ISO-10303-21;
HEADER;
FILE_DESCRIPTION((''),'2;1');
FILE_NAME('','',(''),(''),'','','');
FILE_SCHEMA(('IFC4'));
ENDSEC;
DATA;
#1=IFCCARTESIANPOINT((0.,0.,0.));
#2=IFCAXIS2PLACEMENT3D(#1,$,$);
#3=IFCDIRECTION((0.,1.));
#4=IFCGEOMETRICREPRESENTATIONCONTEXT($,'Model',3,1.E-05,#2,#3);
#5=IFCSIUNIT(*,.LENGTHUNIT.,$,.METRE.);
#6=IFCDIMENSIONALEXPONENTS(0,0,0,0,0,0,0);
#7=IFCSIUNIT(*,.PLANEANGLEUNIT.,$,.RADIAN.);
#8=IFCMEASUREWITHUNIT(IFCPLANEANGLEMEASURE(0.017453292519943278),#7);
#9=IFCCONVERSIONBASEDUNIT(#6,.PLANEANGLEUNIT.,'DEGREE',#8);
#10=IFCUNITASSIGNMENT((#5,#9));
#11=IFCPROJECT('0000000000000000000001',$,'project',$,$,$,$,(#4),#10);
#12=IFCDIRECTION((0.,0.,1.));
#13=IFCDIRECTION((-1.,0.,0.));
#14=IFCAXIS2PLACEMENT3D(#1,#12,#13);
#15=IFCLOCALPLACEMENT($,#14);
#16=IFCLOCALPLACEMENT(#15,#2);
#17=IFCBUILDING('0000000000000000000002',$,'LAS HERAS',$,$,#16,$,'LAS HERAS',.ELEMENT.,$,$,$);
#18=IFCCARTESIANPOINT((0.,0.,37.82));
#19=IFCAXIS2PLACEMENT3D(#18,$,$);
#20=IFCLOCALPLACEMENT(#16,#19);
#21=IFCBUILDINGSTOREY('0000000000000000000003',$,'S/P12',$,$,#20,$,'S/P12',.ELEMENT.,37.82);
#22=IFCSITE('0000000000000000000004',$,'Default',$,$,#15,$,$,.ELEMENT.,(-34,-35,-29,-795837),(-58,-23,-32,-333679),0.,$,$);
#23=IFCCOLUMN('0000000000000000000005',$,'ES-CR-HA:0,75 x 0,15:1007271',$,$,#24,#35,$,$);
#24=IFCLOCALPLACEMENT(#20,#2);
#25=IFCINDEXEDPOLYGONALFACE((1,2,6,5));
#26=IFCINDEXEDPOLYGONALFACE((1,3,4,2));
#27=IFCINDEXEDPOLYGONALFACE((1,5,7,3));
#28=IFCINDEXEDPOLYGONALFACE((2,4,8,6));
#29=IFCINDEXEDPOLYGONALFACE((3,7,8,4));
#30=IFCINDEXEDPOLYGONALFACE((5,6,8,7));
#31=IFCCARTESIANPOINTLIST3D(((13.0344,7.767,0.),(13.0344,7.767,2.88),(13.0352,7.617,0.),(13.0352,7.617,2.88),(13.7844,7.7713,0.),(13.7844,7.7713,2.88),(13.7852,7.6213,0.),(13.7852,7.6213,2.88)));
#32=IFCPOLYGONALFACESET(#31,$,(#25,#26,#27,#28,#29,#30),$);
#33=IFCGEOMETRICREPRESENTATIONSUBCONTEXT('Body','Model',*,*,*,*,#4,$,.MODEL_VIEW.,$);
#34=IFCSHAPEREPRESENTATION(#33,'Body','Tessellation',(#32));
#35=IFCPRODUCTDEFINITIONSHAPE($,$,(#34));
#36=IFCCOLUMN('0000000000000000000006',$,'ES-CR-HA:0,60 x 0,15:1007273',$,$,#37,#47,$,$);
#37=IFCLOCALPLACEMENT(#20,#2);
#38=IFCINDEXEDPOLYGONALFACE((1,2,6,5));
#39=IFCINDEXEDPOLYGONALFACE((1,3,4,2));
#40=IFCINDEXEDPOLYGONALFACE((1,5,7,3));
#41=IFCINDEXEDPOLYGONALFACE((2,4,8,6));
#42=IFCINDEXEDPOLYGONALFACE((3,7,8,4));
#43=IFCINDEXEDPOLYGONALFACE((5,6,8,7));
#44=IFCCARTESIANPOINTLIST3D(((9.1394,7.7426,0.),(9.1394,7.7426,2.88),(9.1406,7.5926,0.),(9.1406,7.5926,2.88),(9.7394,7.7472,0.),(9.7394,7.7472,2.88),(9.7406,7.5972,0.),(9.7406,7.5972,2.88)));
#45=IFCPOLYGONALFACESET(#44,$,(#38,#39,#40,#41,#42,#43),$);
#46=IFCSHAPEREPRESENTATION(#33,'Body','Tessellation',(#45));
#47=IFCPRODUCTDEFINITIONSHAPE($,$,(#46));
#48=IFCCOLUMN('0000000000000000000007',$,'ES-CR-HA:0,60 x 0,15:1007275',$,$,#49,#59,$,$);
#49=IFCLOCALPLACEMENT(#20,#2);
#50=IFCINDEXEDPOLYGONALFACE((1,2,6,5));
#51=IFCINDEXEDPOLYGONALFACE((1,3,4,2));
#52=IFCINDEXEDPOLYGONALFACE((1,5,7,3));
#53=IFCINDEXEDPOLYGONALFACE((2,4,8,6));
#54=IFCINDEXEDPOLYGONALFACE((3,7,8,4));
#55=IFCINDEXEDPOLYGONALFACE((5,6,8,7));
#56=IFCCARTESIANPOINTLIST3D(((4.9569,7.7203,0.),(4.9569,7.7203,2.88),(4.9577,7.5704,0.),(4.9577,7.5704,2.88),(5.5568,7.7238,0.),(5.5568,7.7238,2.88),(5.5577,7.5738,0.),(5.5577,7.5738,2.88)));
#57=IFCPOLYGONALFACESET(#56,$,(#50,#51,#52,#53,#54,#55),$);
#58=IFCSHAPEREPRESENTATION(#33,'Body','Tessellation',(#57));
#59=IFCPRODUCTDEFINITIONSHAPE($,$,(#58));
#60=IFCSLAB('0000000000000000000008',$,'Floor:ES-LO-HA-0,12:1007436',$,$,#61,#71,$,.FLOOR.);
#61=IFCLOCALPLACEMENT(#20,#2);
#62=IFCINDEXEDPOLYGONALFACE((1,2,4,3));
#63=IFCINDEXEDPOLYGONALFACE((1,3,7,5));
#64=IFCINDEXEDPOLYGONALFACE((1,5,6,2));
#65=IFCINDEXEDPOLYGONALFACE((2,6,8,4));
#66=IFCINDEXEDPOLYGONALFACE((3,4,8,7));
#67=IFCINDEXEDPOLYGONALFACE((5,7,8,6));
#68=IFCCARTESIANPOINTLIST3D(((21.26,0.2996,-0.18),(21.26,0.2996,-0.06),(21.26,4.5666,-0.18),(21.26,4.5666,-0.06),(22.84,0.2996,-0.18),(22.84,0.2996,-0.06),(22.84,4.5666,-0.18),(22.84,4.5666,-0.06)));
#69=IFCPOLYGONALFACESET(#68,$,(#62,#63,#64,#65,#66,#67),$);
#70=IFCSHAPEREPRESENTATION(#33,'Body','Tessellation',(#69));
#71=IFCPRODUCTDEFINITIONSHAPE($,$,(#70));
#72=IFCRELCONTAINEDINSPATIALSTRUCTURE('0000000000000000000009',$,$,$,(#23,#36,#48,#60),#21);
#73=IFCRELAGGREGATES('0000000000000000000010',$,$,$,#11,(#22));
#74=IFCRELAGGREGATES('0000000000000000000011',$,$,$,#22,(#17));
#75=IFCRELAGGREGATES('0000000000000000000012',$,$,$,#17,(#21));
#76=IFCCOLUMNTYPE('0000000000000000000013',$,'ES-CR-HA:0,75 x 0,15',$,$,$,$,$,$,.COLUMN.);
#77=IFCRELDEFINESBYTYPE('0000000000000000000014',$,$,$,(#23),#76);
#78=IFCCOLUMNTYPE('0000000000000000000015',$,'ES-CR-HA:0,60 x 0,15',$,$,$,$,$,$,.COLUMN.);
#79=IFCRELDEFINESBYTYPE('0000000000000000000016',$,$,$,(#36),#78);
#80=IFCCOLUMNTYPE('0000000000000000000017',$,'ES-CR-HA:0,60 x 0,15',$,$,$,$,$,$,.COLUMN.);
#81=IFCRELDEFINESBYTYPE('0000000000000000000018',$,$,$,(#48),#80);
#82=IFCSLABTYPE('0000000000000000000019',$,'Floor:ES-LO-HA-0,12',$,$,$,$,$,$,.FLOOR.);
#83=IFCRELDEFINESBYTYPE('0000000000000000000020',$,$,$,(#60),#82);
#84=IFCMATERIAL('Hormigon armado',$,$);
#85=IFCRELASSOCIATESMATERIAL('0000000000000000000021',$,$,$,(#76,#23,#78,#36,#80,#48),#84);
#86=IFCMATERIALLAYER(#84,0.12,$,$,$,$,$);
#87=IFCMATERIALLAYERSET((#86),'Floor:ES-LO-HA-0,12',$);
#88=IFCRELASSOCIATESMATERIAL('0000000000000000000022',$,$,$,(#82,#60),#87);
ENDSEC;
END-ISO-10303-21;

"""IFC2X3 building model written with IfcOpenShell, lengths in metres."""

from ifc_helpers import new_model, entity, si_unit, converted_unit, direction, frame, frame_2d, origin, origin_2d_with_axis, place, context, subcontext, project, spatial, rectangle, extrude, source, transform, mapped, material, layer, layer_set, layer_usage, type_object, type_shapes, element, save


model = new_model("IFC2X3")

# Units and contexts
model_context = context("Model", 3, precision=1e-05, world=origin(), true_north=direction((0.0, 1.0)))
body_context = subcontext(model_context, "Body", "Model", "MODEL_VIEW")
ifc_project = project(units=[si_unit("LENGTHUNIT", "METRE"), converted_unit("PLANEANGLEUNIT", "DEGREE", entity("IfcPlaneAngleMeasure", 0.017453292519943278), si_unit("PLANEANGLEUNIT", "RADIAN"), dimensions=[0, 0, 0, 0, 0, 0, 0])], contexts=[model_context])

# Site, building, storey
site_placement = place(None, frame((0.0, 0.0, 0.0), z_axis=(0.0, 0.0, 1.0), x_axis=(-1.0, 0.0, 0.0)))
site = spatial("IfcSite", under=ifc_project, at=site_placement, Name="Default", CompositionType="ELEMENT", RefLatitude=(-34, -35, -29, -795837), RefLongitude=(-58, -23, -32, -333679), RefElevation=0.0)
building_placement = place(site_placement, origin())
building = spatial("IfcBuilding", under=site, at=building_placement, Name="LAS HERAS", LongName="LAS HERAS", CompositionType="ELEMENT")
storey_placement = place(building_placement, frame((0.0, 0.0, 37.82)))
storey = spatial("IfcBuildingStorey", under=building, at=storey_placement, Name="S/P12", LongName="S/P12", CompositionType="ELEMENT", Elevation=37.82)

# Columns
ifc_material = material(Name="Hormigon armado")
column_type_1 = type_object("IfcColumnType", Name="ES-CR-HA:0,75 x 0,15", PredefinedType="COLUMN", material=ifc_material)
shared_shape_1 = source(origin(), body_context, "Body", "SweptSolid", [
    extrude(rectangle(XDim=0.75, YDim=0.15, at=origin_2d_with_axis()), frame((13.4098, 7.6942, 37.82), z_axis=(0.0, 0.0, 1.0), x_axis=(-0.999983, -0.005788, 0.0)), (0.0, 0.0, 1.0), 2.88),
])
type_shapes(column_type_1, [shared_shape_1])
column_1_placement = place(storey_placement, frame((0.0, 0.0, -37.82)))
element("IfcColumn", 1, at=column_1_placement, inside=storey, type_object=column_type_1, material=ifc_material, Name="ES-CR-HA:0,75 x 0,15:1007271", context=body_context, shape_type="MappedRepresentation", body=[
    mapped(shared_shape_1, transform((0.0, 0.0, 0.0), scale=1.0)),
])
column_type_2 = type_object("IfcColumnType", Name="ES-CR-HA:0,60 x 0,15", PredefinedType="COLUMN", material=ifc_material)
shared_shape_2 = source(origin(), body_context, "Body", "SweptSolid", [
    extrude(rectangle(XDim=0.6, YDim=0.15, at=origin_2d_with_axis()), frame((9.44, 7.6699, 37.82), z_axis=(0.0, 0.0, 1.0), x_axis=(-0.99997, -0.007732, 0.0)), (0.0, 0.0, 1.0), 2.88),
])
type_shapes(column_type_2, [shared_shape_2])
column_2_placement = place(storey_placement, frame((0.0, 0.0, -37.82)))
element("IfcColumn", 2, at=column_2_placement, inside=storey, type_object=column_type_2, material=ifc_material, Name="ES-CR-HA:0,60 x 0,15:1007273", context=body_context, shape_type="MappedRepresentation", body=[
    mapped(shared_shape_2, transform((0.0, 0.0, 0.0), scale=1.0)),
])
column_type_3 = type_object("IfcColumnType", Name="ES-CR-HA:0,60 x 0,15", PredefinedType="COLUMN", material=ifc_material)
shared_shape_3 = source(origin(), body_context, "Body", "SweptSolid", [
    extrude(rectangle(XDim=0.6, YDim=0.15, at=frame_2d((0.0, 0.0), x_axis=(1.0, 0.0))), frame((5.2573, 7.6471, 37.82), z_axis=(0.0, 0.0, 1.0), x_axis=(-0.999983, -0.005788, 0.0)), (0.0, 0.0, 1.0), 2.88),
])
type_shapes(column_type_3, [shared_shape_3])
column_3_placement = place(storey_placement, frame((0.0, 0.0, -37.82)))
element("IfcColumn", 3, at=column_3_placement, inside=storey, type_object=column_type_3, material=ifc_material, Name="ES-CR-HA:0,60 x 0,15:1007275", context=body_context, shape_type="MappedRepresentation", body=[
    mapped(shared_shape_3, transform((0.0, 0.0, 0.0), scale=1.0)),
])

# Slab
ifc_layer_1 = layer(ifc_material, 0.12)
ifc_layer_set_1 = layer_set([ifc_layer_1], Name="Floor:ES-LO-HA-0,12")
ifc_layer_usage_1 = layer_usage(ifc_layer_set_1, "AXIS3", "POSITIVE", 0.0)
slab_type_1 = type_object("IfcSlabType", Name="Floor:ES-LO-HA-0,12", PredefinedType="FLOOR", material=ifc_layer_set_1)
slab_1_placement = place(storey_placement, origin())
element("IfcSlab", 4, at=slab_1_placement, inside=storey, type_object=slab_type_1, material=ifc_layer_usage_1, Name="Floor:ES-LO-HA-0,12:1007436", PredefinedType="FLOOR", context=body_context, shape_type="SweptSolid", body=[
    extrude(rectangle(XDim=4.2671, YDim=1.58, at=frame_2d((0.0, 0.0), x_axis=(1.0, 0.0))), frame((22.05, 2.4331, -0.06), z_axis=(0.0, 0.0, -1.0), x_axis=(0.0, 1.0, 0.0)), (0.0, 0.0, 1.0), 0.12),
])

save(model, "model.ifc")
